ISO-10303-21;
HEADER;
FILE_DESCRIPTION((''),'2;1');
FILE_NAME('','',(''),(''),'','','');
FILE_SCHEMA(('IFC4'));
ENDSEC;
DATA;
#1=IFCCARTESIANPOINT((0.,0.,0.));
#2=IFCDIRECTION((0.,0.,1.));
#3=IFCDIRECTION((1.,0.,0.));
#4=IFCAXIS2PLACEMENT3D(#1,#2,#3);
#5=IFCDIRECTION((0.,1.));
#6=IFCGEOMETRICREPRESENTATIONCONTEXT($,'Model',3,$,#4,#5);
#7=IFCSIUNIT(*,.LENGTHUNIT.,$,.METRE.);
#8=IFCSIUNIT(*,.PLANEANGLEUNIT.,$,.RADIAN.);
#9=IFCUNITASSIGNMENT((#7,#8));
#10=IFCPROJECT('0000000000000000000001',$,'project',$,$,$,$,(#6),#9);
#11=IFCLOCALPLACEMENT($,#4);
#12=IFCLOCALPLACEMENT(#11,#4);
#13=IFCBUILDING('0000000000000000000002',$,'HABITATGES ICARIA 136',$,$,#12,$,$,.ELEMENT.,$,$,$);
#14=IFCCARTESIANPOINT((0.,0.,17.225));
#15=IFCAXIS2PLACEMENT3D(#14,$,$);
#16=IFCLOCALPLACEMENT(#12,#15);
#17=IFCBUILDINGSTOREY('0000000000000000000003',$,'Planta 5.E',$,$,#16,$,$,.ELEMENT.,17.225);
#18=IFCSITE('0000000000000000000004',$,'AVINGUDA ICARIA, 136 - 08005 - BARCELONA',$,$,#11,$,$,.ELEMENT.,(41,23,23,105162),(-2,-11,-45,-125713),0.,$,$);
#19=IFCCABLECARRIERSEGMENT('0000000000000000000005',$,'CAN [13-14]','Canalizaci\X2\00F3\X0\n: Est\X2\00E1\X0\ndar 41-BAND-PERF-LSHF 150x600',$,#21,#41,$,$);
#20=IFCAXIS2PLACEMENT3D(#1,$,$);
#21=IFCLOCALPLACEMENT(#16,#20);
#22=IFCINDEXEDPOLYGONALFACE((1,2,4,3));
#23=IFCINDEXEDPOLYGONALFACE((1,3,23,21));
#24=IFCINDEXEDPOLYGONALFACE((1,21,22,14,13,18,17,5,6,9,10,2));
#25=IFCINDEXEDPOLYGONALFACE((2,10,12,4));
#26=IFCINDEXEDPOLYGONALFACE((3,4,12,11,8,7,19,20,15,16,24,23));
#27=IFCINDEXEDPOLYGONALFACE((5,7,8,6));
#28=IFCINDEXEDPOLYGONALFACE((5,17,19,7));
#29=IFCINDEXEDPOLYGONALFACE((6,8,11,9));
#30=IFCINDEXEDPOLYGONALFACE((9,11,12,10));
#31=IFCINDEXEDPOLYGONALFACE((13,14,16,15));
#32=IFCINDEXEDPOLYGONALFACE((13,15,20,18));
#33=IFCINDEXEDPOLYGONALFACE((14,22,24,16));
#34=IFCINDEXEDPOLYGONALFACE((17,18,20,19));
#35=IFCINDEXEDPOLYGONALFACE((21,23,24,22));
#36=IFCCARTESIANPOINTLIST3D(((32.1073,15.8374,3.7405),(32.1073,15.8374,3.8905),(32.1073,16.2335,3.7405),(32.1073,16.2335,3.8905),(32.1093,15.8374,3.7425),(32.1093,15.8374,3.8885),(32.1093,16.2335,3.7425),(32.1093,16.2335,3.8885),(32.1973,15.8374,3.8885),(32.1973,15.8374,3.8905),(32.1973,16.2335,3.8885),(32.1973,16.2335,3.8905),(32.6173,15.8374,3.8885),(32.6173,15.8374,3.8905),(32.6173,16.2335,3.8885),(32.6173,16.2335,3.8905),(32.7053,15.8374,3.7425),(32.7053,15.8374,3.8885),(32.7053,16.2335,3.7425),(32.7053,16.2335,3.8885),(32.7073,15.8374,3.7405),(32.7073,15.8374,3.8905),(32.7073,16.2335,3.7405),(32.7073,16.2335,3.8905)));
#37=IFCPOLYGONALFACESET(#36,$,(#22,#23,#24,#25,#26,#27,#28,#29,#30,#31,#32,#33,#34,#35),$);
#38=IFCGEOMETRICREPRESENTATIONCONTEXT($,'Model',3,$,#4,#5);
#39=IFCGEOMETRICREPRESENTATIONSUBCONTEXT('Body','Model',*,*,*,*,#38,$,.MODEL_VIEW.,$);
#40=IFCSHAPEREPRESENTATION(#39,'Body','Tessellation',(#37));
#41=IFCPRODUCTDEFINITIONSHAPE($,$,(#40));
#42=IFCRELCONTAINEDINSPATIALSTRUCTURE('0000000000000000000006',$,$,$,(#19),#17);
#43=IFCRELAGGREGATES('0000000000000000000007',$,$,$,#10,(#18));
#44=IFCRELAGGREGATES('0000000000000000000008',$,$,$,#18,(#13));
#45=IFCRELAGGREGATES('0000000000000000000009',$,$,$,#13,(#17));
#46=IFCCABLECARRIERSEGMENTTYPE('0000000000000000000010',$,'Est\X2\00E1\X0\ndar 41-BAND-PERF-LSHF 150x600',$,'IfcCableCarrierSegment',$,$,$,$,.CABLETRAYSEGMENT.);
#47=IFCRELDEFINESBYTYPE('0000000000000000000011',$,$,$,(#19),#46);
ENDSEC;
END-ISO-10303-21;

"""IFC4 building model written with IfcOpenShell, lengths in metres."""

from ifc_helpers import new_model, si_unit, direction, frame, origin_with_axes, place, context, subcontext, project, spatial, polyline, outline, extrude, type_object, element, save


model = new_model("IFC4")

# Units and contexts
model_context_1 = context("Model", 3, world=origin_with_axes(), true_north=direction((0.0, 1.0)))
model_context_2 = context("Model", 3, world=origin_with_axes(), true_north=direction((0.0, 1.0)))
body_context = subcontext(model_context_2, "Body", "Model", "MODEL_VIEW")
ifc_project = project(units=[si_unit("LENGTHUNIT", "METRE"), si_unit("PLANEANGLEUNIT", "RADIAN")], contexts=[model_context_1])

# Site, building, storey
site_placement = place(None, origin_with_axes())
site = spatial("IfcSite", under=ifc_project, at=site_placement, Name="AVINGUDA ICARIA, 136 - 08005 - BARCELONA", CompositionType="ELEMENT", RefLatitude=(41, 23, 23, 105162), RefLongitude=(-2, -11, -45, -125713), RefElevation=0.0)
building_placement = place(site_placement, origin_with_axes())
building = spatial("IfcBuilding", under=site, at=building_placement, Name="HABITATGES ICARIA 136", CompositionType="ELEMENT")
storey_placement = place(building_placement, frame((0.0, 0.0, 17.225)))
storey = spatial("IfcBuildingStorey", under=building, at=storey_placement, Name="Planta 5.E", CompositionType="ELEMENT", Elevation=17.225)

# Cable carrier segment
cable_carrier_segment_type = type_object("IfcCableCarrierSegmentType", Name="Estándar 41-BAND-PERF-LSHF 150x600", ApplicableOccurrence="IfcCableCarrierSegment", PredefinedType="CABLETRAYSEGMENT")
placement_1 = place(None, origin_with_axes())
placement_2 = place(placement_1, origin_with_axes())
placement_3 = place(placement_2, frame((0.0, 0.0, 17.225)))
cable_carrier_segment_placement = place(placement_3, origin_with_axes())
element("IfcCableCarrierSegment", 1, at=cable_carrier_segment_placement, inside=storey, type_object=cable_carrier_segment_type, Name="CAN [13-14]", Description="Canalización: Estándar 41-BAND-PERF-LSHF 150x600", context=body_context, shape_type="SweptSolid", body=[
    extrude(outline(polyline([(-0.21, 0.148), (-0.21, 0.15), (-0.3, 0.15), (-0.3, 0.0), (0.3, 0.0), (0.3, 0.15), (0.21, 0.15), (0.21, 0.148), (0.298, 0.148), (0.298, 0.002), (-0.298, 0.002), (-0.298, 0.148), (-0.21, 0.148)])), frame((32.4073, 15.8374, 3.7405), z_axis=(0.0, 1.0, 0.0), x_axis=(-1.0, 0.0, 0.0)), (0.0, 0.0, 1.0), 0.3961),
])

save(model, "model.ifc")
